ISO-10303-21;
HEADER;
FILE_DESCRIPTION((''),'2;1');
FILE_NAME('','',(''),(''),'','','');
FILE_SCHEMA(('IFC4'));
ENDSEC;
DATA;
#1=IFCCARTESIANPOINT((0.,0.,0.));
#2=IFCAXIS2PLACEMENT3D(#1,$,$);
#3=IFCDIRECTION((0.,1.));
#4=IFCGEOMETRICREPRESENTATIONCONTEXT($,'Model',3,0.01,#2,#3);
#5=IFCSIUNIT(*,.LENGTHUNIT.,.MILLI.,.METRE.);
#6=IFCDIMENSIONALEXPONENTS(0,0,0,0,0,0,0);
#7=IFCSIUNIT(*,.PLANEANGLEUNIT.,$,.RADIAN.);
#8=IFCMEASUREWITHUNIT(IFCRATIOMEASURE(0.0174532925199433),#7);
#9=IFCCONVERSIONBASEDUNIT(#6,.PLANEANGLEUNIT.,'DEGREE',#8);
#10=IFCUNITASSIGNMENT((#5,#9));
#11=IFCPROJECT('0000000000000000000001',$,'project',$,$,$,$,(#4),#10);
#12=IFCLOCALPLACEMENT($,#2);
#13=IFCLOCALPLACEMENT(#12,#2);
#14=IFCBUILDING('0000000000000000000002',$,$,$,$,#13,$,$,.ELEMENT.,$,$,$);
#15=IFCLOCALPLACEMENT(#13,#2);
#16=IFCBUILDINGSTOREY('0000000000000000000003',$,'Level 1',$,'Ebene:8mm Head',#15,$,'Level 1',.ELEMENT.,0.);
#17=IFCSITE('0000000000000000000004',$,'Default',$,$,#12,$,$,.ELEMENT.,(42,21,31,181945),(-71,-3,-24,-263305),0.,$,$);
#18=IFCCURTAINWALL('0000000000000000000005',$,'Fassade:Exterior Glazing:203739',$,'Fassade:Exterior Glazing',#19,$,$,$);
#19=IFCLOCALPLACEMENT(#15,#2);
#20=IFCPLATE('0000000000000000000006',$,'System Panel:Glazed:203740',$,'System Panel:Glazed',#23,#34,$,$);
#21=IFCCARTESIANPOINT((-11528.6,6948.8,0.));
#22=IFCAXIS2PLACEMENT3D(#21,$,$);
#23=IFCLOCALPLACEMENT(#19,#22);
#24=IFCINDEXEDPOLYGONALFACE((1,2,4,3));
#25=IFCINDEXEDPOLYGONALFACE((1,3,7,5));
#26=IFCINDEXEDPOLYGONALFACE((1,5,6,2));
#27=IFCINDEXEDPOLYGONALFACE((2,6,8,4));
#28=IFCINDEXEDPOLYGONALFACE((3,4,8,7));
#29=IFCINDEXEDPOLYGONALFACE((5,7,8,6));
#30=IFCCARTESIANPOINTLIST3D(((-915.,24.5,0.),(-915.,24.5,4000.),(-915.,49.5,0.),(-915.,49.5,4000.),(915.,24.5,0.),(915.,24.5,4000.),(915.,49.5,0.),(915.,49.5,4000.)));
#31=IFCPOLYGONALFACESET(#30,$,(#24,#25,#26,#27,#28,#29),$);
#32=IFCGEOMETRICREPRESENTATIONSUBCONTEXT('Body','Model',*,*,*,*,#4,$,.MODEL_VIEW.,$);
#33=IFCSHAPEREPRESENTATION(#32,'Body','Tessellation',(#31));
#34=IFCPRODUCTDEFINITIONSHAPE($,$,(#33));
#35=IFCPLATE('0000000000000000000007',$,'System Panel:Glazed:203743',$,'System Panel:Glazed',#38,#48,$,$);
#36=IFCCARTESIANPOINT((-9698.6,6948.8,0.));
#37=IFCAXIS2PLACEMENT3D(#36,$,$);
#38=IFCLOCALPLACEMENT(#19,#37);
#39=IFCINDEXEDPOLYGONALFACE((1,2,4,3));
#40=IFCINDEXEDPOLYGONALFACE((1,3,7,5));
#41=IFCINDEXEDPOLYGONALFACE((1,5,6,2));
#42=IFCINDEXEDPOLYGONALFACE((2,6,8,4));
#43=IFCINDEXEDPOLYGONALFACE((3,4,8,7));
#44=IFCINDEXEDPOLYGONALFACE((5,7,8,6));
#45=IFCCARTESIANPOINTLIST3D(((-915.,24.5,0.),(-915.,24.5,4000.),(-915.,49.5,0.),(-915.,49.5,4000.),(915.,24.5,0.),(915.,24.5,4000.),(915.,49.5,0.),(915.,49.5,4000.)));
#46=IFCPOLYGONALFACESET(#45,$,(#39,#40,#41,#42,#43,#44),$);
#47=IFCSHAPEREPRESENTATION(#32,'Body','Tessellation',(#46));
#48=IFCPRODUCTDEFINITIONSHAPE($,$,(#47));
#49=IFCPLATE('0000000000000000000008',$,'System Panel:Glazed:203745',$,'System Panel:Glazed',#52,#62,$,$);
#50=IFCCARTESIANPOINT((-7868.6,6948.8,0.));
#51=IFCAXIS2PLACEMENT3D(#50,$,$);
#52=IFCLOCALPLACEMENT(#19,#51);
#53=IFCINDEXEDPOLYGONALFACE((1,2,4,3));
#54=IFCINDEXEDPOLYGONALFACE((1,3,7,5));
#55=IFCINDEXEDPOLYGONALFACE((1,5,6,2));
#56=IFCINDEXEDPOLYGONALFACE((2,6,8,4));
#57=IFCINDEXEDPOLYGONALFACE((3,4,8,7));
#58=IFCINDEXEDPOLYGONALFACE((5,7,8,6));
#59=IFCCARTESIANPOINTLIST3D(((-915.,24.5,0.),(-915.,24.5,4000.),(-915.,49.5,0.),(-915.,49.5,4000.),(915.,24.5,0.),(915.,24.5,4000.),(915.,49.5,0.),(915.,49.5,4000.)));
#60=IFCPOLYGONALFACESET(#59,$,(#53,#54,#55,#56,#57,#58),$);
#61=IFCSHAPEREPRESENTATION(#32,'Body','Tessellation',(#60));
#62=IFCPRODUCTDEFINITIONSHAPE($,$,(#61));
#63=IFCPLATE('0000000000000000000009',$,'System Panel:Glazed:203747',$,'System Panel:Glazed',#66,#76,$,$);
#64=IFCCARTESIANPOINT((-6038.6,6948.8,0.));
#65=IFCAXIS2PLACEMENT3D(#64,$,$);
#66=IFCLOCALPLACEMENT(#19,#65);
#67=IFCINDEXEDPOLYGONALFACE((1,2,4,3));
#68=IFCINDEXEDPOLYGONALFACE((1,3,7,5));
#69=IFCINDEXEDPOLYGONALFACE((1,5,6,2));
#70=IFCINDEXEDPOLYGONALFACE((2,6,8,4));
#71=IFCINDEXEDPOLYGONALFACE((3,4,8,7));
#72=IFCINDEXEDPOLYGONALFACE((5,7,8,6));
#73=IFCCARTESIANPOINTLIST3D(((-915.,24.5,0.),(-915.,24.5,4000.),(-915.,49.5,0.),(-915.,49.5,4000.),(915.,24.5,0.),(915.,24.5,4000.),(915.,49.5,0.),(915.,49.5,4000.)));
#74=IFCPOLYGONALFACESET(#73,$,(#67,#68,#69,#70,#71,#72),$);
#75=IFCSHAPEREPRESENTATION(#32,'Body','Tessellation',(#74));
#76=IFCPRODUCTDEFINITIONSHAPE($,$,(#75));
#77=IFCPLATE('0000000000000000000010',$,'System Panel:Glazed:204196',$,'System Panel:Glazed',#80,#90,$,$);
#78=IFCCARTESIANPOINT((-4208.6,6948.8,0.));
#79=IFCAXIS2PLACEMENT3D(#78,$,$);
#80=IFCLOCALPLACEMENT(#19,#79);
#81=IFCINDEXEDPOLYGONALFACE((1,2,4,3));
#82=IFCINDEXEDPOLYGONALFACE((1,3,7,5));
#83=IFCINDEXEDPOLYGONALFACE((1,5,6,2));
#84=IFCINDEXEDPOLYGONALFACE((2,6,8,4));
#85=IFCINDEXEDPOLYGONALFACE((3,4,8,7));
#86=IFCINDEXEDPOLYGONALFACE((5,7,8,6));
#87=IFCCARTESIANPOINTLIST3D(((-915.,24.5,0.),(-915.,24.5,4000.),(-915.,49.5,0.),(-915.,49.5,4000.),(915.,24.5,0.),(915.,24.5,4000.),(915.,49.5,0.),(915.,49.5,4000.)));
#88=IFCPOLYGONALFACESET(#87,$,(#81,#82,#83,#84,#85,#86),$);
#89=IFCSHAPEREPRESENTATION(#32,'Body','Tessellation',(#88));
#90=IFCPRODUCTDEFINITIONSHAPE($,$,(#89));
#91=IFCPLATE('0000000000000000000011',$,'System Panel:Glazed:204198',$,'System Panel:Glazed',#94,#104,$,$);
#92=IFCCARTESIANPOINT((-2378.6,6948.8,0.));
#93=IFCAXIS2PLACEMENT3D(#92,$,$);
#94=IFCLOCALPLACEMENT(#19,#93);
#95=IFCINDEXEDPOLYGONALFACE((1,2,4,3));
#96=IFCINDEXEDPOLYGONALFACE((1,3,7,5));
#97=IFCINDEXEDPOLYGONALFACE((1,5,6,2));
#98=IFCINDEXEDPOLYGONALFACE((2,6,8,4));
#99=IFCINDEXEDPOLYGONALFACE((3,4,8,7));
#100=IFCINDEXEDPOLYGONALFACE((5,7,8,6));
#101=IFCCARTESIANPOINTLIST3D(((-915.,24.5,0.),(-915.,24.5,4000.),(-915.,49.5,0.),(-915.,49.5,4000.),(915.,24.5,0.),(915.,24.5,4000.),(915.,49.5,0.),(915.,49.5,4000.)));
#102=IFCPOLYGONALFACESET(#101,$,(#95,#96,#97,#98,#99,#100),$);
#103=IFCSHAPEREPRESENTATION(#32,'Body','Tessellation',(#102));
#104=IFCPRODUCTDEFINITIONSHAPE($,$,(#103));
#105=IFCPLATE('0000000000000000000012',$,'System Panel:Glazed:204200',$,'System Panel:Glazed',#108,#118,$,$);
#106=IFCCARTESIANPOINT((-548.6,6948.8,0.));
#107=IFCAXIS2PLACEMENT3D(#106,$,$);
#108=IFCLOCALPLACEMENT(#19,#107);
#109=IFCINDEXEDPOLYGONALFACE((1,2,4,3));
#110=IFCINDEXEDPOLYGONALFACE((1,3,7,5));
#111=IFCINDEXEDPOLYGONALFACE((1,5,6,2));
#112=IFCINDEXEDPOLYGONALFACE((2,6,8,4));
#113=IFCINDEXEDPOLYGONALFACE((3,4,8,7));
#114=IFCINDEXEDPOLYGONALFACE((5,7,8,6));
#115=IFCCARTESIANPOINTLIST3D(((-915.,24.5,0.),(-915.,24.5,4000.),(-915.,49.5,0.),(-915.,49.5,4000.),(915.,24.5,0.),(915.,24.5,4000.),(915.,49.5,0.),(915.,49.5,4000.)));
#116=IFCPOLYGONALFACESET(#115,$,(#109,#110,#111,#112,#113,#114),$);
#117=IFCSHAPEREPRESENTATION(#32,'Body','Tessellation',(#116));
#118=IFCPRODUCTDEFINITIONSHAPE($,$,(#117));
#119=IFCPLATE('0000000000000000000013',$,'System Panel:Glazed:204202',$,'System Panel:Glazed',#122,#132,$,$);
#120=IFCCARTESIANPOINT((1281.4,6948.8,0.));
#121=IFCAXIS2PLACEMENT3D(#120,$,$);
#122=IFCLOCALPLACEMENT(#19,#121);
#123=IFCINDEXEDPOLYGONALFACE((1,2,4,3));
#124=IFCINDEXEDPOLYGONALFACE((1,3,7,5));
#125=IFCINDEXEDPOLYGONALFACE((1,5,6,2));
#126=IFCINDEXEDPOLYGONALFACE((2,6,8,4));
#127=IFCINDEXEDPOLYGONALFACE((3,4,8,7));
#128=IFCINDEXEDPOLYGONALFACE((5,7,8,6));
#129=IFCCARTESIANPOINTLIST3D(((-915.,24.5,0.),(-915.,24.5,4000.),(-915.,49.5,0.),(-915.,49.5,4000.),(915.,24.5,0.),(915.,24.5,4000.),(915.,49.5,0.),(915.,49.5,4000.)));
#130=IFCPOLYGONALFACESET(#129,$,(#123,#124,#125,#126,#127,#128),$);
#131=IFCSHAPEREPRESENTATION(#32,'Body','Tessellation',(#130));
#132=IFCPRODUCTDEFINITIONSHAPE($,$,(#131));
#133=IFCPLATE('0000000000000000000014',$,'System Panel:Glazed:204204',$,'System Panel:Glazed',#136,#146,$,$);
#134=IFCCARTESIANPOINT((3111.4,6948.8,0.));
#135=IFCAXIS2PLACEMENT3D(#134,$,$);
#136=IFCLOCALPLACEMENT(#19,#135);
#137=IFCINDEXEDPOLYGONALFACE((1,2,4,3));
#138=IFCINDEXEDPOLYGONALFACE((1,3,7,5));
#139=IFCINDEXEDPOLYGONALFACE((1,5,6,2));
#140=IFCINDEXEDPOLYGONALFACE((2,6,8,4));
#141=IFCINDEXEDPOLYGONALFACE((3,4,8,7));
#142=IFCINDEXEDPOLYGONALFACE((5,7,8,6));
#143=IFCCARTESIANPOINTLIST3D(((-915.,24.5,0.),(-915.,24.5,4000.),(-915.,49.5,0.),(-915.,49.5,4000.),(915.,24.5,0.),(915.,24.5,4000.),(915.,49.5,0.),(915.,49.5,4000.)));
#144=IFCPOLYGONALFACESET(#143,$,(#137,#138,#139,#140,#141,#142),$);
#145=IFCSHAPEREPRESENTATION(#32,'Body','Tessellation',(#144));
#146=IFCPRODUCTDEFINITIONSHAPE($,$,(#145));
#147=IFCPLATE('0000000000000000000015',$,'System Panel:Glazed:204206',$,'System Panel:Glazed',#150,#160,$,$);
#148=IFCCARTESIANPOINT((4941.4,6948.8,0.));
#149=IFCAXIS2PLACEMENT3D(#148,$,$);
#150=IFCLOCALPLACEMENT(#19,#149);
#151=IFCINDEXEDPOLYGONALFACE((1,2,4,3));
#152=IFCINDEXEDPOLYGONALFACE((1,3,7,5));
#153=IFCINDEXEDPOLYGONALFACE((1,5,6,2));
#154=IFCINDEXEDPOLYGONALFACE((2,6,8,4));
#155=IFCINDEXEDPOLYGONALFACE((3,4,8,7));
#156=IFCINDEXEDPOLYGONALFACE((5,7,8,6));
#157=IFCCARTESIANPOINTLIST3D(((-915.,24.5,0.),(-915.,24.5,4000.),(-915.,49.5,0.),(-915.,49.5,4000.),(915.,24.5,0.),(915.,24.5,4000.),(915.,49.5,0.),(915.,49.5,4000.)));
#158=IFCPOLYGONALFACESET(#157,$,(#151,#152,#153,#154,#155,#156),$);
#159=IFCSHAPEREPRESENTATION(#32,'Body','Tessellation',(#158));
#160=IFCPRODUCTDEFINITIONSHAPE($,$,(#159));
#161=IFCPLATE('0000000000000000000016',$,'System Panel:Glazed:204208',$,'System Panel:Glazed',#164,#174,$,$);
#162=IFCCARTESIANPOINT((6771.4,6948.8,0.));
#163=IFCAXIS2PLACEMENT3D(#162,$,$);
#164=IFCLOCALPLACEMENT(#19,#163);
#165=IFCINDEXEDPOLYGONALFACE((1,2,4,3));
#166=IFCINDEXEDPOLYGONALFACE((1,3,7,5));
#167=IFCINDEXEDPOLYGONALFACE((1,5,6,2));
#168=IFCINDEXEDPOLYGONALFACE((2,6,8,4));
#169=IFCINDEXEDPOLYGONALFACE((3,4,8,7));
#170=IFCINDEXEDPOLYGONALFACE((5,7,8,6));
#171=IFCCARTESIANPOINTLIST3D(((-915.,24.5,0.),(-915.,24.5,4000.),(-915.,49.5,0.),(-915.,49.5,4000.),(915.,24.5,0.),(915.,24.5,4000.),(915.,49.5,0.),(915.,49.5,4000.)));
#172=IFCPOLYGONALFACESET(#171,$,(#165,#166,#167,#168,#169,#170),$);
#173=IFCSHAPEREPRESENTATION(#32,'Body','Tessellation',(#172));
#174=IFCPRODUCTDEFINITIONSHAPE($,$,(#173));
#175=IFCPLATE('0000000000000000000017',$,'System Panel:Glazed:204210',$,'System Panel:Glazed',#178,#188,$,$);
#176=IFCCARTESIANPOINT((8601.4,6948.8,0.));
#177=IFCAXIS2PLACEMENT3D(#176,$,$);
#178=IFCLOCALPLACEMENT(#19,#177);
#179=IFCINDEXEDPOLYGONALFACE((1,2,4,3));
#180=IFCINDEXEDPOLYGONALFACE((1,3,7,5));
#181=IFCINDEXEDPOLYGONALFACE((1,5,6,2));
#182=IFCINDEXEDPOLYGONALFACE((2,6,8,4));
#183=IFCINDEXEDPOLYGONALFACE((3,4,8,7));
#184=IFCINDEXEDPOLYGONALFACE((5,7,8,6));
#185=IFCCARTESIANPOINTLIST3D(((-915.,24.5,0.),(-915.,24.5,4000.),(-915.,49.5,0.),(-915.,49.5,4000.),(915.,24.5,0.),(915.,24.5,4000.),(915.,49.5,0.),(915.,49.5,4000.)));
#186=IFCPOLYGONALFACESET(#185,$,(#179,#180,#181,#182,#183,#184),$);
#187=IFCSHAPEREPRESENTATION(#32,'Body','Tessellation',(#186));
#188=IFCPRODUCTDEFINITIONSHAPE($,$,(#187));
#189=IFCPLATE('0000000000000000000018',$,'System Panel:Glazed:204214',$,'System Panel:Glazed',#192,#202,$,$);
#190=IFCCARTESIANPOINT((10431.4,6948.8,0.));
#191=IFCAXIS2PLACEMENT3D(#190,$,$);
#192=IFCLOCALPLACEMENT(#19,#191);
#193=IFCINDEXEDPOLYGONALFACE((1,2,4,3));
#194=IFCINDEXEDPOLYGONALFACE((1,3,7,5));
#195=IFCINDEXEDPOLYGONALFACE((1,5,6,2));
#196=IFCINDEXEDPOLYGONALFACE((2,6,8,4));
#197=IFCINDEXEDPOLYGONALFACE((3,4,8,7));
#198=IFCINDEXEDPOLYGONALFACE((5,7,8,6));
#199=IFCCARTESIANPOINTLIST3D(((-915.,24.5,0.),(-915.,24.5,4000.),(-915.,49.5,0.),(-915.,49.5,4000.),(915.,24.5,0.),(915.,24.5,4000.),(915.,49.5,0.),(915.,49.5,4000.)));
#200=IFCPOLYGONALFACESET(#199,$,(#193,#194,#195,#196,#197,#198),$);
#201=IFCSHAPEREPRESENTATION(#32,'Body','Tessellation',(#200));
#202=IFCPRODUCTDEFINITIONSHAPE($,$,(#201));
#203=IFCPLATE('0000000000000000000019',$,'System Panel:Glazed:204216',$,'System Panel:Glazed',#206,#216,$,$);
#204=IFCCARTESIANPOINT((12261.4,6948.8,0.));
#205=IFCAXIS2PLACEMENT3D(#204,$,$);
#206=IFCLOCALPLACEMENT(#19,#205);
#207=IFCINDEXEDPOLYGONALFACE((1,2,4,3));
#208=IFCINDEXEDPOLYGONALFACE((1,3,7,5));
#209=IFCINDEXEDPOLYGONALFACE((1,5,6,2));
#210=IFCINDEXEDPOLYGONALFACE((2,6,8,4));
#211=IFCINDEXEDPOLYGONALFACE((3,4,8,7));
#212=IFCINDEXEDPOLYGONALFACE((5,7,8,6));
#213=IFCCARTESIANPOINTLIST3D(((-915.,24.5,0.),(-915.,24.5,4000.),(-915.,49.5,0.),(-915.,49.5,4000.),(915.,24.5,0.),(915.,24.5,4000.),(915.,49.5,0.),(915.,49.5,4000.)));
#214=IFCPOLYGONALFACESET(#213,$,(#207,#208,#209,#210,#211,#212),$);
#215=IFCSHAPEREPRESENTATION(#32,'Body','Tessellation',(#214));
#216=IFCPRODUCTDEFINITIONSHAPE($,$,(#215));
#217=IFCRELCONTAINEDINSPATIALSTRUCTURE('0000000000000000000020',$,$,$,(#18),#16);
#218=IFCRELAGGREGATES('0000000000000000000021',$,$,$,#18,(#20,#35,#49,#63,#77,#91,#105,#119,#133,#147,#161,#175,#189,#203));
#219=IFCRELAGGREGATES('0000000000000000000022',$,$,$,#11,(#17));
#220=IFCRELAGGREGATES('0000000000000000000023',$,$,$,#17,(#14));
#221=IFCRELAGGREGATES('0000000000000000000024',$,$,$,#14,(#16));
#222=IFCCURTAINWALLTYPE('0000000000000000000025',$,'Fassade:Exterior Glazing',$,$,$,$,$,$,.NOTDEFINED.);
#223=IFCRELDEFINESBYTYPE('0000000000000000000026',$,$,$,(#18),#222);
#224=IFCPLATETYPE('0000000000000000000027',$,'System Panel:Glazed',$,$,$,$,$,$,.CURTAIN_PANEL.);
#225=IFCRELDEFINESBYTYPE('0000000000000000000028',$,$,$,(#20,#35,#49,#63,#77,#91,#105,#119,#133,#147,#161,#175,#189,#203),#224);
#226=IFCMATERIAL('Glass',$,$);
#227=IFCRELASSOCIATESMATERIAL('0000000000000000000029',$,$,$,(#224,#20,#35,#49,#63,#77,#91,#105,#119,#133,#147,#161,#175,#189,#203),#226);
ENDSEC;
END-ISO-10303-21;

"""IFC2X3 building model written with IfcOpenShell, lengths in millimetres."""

from ifc_helpers import new_model, entity, si_unit, converted_unit, direction, frame, origin, origin_2d_with_axis, place, context, subcontext, project, spatial, rectangle, extrude, source, transform, mapped, material, type_object, type_shapes, element, aggregate, save


model = new_model("IFC2X3")

# Units and contexts
model_context = context("Model", 3, precision=0.01, world=origin(), true_north=direction((0.0, 1.0)))
body_context = subcontext(model_context, "Body", "Model", "MODEL_VIEW")
ifc_project = project(units=[si_unit("LENGTHUNIT", "METRE", prefix="MILLI"), converted_unit("PLANEANGLEUNIT", "DEGREE", entity("IfcRatioMeasure", 0.0174532925199433), si_unit("PLANEANGLEUNIT", "RADIAN"), dimensions=[0, 0, 0, 0, 0, 0, 0])], contexts=[model_context])

# Site, building, storey
site_placement = place(None, origin())
site = spatial("IfcSite", under=ifc_project, at=site_placement, Name="Default", CompositionType="ELEMENT", RefLatitude=(42, 21, 31, 181945), RefLongitude=(-71, -3, -24, -263305), RefElevation=0.0)
building_placement = place(site_placement, origin())
building = spatial("IfcBuilding", under=site, at=building_placement, CompositionType="ELEMENT")
storey_placement = place(building_placement, origin())
storey = spatial("IfcBuildingStorey", under=building, at=storey_placement, Name="Level 1", ObjectType="Ebene:8mm Head", LongName="Level 1", CompositionType="ELEMENT", Elevation=0.0)

# Curtain wall, plates
curtain_wall_type = type_object("IfcCurtainWallType", Name="Fassade:Exterior Glazing", PredefinedType="NOTDEFINED")
curtain_wall_placement = place(storey_placement, origin())
curtain_wall = element("IfcCurtainWall", 1, at=curtain_wall_placement, inside=storey, type_object=curtain_wall_type, Name="Fassade:Exterior Glazing:203739", ObjectType="Fassade:Exterior Glazing")
ifc_material_1 = material(Name="Glass")
plate_type_1 = type_object("IfcPlateType", Name="System Panel:Glazed", PredefinedType="CURTAIN_PANEL", material=ifc_material_1)
shared_shape_1 = source(origin(), body_context, "Body", "SweptSolid", [
    extrude(rectangle(XDim=25.0, YDim=1830.0, at=origin_2d_with_axis()), frame((0.0, 37.0, 0.0), z_axis=(0.0, 0.0, 1.0), x_axis=(0.0, 1.0, 0.0)), (0.0, 0.0, 1.0), 4000.0),
])
type_shapes(plate_type_1, [shared_shape_1])
plate_1_placement = place(curtain_wall_placement, frame((-11528.6, 6948.8, 0.0)))
plate_1 = element("IfcPlate", 2, at=plate_1_placement, type_object=plate_type_1, material=ifc_material_1, Name="System Panel:Glazed:203740", ObjectType="System Panel:Glazed", context=body_context, shape_type="MappedRepresentation", body=[
    mapped(shared_shape_1, transform((0.0, 0.0, 0.0), scale=1.0)),
])
plate_2_placement = place(curtain_wall_placement, frame((-9698.6, 6948.8, 0.0)))
plate_2 = element("IfcPlate", 3, at=plate_2_placement, type_object=plate_type_1, material=ifc_material_1, Name="System Panel:Glazed:203743", ObjectType="System Panel:Glazed", context=body_context, shape_type="MappedRepresentation", body=[
    mapped(shared_shape_1, transform((0.0, 0.0, 0.0), scale=1.0)),
])
plate_3_placement = place(curtain_wall_placement, frame((-7868.6, 6948.8, 0.0)))
plate_3 = element("IfcPlate", 4, at=plate_3_placement, type_object=plate_type_1, material=ifc_material_1, Name="System Panel:Glazed:203745", ObjectType="System Panel:Glazed", context=body_context, shape_type="MappedRepresentation", body=[
    mapped(shared_shape_1, transform((0.0, 0.0, 0.0), scale=1.0)),
])
plate_4_placement = place(curtain_wall_placement, frame((-6038.6, 6948.8, 0.0)))
plate_4 = element("IfcPlate", 5, at=plate_4_placement, type_object=plate_type_1, material=ifc_material_1, Name="System Panel:Glazed:203747", ObjectType="System Panel:Glazed", context=body_context, shape_type="MappedRepresentation", body=[
    mapped(shared_shape_1, transform((0.0, 0.0, 0.0), scale=1.0)),
])
plate_5_placement = place(curtain_wall_placement, frame((-4208.6, 6948.8, 0.0)))
plate_5 = element("IfcPlate", 6, at=plate_5_placement, type_object=plate_type_1, material=ifc_material_1, Name="System Panel:Glazed:204196", ObjectType="System Panel:Glazed", context=body_context, shape_type="MappedRepresentation", body=[
    mapped(shared_shape_1, transform((0.0, 0.0, 0.0), scale=1.0)),
])
plate_6_placement = place(curtain_wall_placement, frame((-2378.6, 6948.8, 0.0)))
plate_6 = element("IfcPlate", 7, at=plate_6_placement, type_object=plate_type_1, material=ifc_material_1, Name="System Panel:Glazed:204198", ObjectType="System Panel:Glazed", context=body_context, shape_type="MappedRepresentation", body=[
    mapped(shared_shape_1, transform((0.0, 0.0, 0.0), scale=1.0)),
])
plate_7_placement = place(curtain_wall_placement, frame((-548.6, 6948.8, 0.0)))
plate_7 = element("IfcPlate", 8, at=plate_7_placement, type_object=plate_type_1, material=ifc_material_1, Name="System Panel:Glazed:204200", ObjectType="System Panel:Glazed", context=body_context, shape_type="MappedRepresentation", body=[
    mapped(shared_shape_1, transform((0.0, 0.0, 0.0), scale=1.0)),
])
plate_8_placement = place(curtain_wall_placement, frame((1281.4, 6948.8, 0.0)))
plate_8 = element("IfcPlate", 9, at=plate_8_placement, type_object=plate_type_1, material=ifc_material_1, Name="System Panel:Glazed:204202", ObjectType="System Panel:Glazed", context=body_context, shape_type="MappedRepresentation", body=[
    mapped(shared_shape_1, transform((0.0, 0.0, 0.0), scale=1.0)),
])
plate_9_placement = place(curtain_wall_placement, frame((3111.4, 6948.8, 0.0)))
plate_9 = element("IfcPlate", 10, at=plate_9_placement, type_object=plate_type_1, material=ifc_material_1, Name="System Panel:Glazed:204204", ObjectType="System Panel:Glazed", context=body_context, shape_type="MappedRepresentation", body=[
    mapped(shared_shape_1, transform((0.0, 0.0, 0.0), scale=1.0)),
])
plate_10_placement = place(curtain_wall_placement, frame((4941.4, 6948.8, 0.0)))
plate_10 = element("IfcPlate", 11, at=plate_10_placement, type_object=plate_type_1, material=ifc_material_1, Name="System Panel:Glazed:204206", ObjectType="System Panel:Glazed", context=body_context, shape_type="MappedRepresentation", body=[
    mapped(shared_shape_1, transform((0.0, 0.0, 0.0), scale=1.0)),
])
plate_11_placement = place(curtain_wall_placement, frame((6771.4, 6948.8, 0.0)))
plate_11 = element("IfcPlate", 12, at=plate_11_placement, type_object=plate_type_1, material=ifc_material_1, Name="System Panel:Glazed:204208", ObjectType="System Panel:Glazed", context=body_context, shape_type="MappedRepresentation", body=[
    mapped(shared_shape_1, transform((0.0, 0.0, 0.0), scale=1.0)),
])
plate_12_placement = place(curtain_wall_placement, frame((8601.4, 6948.8, 0.0)))
plate_12 = element("IfcPlate", 13, at=plate_12_placement, type_object=plate_type_1, material=ifc_material_1, Name="System Panel:Glazed:204210", ObjectType="System Panel:Glazed", context=body_context, shape_type="MappedRepresentation", body=[
    mapped(shared_shape_1, transform((0.0, 0.0, 0.0), scale=1.0)),
])
plate_13_placement = place(curtain_wall_placement, frame((10431.4, 6948.8, 0.0)))
plate_13 = element("IfcPlate", 14, at=plate_13_placement, type_object=plate_type_1, material=ifc_material_1, Name="System Panel:Glazed:204214", ObjectType="System Panel:Glazed", context=body_context, shape_type="MappedRepresentation", body=[
    mapped(shared_shape_1, transform((0.0, 0.0, 0.0), scale=1.0)),
])
plate_14_placement = place(curtain_wall_placement, frame((12261.4, 6948.8, 0.0)))
plate_14 = element("IfcPlate", 15, at=plate_14_placement, type_object=plate_type_1, material=ifc_material_1, Name="System Panel:Glazed:204216", ObjectType="System Panel:Glazed", context=body_context, shape_type="MappedRepresentation", body=[
    mapped(shared_shape_1, transform((0.0, 0.0, 0.0), scale=1.0)),
])
aggregate(curtain_wall, [plate_1, plate_2, plate_3, plate_4, plate_5, plate_6, plate_7, plate_8, plate_9, plate_10, plate_11, plate_12, plate_13, plate_14])

save(model, "model.ifc")
